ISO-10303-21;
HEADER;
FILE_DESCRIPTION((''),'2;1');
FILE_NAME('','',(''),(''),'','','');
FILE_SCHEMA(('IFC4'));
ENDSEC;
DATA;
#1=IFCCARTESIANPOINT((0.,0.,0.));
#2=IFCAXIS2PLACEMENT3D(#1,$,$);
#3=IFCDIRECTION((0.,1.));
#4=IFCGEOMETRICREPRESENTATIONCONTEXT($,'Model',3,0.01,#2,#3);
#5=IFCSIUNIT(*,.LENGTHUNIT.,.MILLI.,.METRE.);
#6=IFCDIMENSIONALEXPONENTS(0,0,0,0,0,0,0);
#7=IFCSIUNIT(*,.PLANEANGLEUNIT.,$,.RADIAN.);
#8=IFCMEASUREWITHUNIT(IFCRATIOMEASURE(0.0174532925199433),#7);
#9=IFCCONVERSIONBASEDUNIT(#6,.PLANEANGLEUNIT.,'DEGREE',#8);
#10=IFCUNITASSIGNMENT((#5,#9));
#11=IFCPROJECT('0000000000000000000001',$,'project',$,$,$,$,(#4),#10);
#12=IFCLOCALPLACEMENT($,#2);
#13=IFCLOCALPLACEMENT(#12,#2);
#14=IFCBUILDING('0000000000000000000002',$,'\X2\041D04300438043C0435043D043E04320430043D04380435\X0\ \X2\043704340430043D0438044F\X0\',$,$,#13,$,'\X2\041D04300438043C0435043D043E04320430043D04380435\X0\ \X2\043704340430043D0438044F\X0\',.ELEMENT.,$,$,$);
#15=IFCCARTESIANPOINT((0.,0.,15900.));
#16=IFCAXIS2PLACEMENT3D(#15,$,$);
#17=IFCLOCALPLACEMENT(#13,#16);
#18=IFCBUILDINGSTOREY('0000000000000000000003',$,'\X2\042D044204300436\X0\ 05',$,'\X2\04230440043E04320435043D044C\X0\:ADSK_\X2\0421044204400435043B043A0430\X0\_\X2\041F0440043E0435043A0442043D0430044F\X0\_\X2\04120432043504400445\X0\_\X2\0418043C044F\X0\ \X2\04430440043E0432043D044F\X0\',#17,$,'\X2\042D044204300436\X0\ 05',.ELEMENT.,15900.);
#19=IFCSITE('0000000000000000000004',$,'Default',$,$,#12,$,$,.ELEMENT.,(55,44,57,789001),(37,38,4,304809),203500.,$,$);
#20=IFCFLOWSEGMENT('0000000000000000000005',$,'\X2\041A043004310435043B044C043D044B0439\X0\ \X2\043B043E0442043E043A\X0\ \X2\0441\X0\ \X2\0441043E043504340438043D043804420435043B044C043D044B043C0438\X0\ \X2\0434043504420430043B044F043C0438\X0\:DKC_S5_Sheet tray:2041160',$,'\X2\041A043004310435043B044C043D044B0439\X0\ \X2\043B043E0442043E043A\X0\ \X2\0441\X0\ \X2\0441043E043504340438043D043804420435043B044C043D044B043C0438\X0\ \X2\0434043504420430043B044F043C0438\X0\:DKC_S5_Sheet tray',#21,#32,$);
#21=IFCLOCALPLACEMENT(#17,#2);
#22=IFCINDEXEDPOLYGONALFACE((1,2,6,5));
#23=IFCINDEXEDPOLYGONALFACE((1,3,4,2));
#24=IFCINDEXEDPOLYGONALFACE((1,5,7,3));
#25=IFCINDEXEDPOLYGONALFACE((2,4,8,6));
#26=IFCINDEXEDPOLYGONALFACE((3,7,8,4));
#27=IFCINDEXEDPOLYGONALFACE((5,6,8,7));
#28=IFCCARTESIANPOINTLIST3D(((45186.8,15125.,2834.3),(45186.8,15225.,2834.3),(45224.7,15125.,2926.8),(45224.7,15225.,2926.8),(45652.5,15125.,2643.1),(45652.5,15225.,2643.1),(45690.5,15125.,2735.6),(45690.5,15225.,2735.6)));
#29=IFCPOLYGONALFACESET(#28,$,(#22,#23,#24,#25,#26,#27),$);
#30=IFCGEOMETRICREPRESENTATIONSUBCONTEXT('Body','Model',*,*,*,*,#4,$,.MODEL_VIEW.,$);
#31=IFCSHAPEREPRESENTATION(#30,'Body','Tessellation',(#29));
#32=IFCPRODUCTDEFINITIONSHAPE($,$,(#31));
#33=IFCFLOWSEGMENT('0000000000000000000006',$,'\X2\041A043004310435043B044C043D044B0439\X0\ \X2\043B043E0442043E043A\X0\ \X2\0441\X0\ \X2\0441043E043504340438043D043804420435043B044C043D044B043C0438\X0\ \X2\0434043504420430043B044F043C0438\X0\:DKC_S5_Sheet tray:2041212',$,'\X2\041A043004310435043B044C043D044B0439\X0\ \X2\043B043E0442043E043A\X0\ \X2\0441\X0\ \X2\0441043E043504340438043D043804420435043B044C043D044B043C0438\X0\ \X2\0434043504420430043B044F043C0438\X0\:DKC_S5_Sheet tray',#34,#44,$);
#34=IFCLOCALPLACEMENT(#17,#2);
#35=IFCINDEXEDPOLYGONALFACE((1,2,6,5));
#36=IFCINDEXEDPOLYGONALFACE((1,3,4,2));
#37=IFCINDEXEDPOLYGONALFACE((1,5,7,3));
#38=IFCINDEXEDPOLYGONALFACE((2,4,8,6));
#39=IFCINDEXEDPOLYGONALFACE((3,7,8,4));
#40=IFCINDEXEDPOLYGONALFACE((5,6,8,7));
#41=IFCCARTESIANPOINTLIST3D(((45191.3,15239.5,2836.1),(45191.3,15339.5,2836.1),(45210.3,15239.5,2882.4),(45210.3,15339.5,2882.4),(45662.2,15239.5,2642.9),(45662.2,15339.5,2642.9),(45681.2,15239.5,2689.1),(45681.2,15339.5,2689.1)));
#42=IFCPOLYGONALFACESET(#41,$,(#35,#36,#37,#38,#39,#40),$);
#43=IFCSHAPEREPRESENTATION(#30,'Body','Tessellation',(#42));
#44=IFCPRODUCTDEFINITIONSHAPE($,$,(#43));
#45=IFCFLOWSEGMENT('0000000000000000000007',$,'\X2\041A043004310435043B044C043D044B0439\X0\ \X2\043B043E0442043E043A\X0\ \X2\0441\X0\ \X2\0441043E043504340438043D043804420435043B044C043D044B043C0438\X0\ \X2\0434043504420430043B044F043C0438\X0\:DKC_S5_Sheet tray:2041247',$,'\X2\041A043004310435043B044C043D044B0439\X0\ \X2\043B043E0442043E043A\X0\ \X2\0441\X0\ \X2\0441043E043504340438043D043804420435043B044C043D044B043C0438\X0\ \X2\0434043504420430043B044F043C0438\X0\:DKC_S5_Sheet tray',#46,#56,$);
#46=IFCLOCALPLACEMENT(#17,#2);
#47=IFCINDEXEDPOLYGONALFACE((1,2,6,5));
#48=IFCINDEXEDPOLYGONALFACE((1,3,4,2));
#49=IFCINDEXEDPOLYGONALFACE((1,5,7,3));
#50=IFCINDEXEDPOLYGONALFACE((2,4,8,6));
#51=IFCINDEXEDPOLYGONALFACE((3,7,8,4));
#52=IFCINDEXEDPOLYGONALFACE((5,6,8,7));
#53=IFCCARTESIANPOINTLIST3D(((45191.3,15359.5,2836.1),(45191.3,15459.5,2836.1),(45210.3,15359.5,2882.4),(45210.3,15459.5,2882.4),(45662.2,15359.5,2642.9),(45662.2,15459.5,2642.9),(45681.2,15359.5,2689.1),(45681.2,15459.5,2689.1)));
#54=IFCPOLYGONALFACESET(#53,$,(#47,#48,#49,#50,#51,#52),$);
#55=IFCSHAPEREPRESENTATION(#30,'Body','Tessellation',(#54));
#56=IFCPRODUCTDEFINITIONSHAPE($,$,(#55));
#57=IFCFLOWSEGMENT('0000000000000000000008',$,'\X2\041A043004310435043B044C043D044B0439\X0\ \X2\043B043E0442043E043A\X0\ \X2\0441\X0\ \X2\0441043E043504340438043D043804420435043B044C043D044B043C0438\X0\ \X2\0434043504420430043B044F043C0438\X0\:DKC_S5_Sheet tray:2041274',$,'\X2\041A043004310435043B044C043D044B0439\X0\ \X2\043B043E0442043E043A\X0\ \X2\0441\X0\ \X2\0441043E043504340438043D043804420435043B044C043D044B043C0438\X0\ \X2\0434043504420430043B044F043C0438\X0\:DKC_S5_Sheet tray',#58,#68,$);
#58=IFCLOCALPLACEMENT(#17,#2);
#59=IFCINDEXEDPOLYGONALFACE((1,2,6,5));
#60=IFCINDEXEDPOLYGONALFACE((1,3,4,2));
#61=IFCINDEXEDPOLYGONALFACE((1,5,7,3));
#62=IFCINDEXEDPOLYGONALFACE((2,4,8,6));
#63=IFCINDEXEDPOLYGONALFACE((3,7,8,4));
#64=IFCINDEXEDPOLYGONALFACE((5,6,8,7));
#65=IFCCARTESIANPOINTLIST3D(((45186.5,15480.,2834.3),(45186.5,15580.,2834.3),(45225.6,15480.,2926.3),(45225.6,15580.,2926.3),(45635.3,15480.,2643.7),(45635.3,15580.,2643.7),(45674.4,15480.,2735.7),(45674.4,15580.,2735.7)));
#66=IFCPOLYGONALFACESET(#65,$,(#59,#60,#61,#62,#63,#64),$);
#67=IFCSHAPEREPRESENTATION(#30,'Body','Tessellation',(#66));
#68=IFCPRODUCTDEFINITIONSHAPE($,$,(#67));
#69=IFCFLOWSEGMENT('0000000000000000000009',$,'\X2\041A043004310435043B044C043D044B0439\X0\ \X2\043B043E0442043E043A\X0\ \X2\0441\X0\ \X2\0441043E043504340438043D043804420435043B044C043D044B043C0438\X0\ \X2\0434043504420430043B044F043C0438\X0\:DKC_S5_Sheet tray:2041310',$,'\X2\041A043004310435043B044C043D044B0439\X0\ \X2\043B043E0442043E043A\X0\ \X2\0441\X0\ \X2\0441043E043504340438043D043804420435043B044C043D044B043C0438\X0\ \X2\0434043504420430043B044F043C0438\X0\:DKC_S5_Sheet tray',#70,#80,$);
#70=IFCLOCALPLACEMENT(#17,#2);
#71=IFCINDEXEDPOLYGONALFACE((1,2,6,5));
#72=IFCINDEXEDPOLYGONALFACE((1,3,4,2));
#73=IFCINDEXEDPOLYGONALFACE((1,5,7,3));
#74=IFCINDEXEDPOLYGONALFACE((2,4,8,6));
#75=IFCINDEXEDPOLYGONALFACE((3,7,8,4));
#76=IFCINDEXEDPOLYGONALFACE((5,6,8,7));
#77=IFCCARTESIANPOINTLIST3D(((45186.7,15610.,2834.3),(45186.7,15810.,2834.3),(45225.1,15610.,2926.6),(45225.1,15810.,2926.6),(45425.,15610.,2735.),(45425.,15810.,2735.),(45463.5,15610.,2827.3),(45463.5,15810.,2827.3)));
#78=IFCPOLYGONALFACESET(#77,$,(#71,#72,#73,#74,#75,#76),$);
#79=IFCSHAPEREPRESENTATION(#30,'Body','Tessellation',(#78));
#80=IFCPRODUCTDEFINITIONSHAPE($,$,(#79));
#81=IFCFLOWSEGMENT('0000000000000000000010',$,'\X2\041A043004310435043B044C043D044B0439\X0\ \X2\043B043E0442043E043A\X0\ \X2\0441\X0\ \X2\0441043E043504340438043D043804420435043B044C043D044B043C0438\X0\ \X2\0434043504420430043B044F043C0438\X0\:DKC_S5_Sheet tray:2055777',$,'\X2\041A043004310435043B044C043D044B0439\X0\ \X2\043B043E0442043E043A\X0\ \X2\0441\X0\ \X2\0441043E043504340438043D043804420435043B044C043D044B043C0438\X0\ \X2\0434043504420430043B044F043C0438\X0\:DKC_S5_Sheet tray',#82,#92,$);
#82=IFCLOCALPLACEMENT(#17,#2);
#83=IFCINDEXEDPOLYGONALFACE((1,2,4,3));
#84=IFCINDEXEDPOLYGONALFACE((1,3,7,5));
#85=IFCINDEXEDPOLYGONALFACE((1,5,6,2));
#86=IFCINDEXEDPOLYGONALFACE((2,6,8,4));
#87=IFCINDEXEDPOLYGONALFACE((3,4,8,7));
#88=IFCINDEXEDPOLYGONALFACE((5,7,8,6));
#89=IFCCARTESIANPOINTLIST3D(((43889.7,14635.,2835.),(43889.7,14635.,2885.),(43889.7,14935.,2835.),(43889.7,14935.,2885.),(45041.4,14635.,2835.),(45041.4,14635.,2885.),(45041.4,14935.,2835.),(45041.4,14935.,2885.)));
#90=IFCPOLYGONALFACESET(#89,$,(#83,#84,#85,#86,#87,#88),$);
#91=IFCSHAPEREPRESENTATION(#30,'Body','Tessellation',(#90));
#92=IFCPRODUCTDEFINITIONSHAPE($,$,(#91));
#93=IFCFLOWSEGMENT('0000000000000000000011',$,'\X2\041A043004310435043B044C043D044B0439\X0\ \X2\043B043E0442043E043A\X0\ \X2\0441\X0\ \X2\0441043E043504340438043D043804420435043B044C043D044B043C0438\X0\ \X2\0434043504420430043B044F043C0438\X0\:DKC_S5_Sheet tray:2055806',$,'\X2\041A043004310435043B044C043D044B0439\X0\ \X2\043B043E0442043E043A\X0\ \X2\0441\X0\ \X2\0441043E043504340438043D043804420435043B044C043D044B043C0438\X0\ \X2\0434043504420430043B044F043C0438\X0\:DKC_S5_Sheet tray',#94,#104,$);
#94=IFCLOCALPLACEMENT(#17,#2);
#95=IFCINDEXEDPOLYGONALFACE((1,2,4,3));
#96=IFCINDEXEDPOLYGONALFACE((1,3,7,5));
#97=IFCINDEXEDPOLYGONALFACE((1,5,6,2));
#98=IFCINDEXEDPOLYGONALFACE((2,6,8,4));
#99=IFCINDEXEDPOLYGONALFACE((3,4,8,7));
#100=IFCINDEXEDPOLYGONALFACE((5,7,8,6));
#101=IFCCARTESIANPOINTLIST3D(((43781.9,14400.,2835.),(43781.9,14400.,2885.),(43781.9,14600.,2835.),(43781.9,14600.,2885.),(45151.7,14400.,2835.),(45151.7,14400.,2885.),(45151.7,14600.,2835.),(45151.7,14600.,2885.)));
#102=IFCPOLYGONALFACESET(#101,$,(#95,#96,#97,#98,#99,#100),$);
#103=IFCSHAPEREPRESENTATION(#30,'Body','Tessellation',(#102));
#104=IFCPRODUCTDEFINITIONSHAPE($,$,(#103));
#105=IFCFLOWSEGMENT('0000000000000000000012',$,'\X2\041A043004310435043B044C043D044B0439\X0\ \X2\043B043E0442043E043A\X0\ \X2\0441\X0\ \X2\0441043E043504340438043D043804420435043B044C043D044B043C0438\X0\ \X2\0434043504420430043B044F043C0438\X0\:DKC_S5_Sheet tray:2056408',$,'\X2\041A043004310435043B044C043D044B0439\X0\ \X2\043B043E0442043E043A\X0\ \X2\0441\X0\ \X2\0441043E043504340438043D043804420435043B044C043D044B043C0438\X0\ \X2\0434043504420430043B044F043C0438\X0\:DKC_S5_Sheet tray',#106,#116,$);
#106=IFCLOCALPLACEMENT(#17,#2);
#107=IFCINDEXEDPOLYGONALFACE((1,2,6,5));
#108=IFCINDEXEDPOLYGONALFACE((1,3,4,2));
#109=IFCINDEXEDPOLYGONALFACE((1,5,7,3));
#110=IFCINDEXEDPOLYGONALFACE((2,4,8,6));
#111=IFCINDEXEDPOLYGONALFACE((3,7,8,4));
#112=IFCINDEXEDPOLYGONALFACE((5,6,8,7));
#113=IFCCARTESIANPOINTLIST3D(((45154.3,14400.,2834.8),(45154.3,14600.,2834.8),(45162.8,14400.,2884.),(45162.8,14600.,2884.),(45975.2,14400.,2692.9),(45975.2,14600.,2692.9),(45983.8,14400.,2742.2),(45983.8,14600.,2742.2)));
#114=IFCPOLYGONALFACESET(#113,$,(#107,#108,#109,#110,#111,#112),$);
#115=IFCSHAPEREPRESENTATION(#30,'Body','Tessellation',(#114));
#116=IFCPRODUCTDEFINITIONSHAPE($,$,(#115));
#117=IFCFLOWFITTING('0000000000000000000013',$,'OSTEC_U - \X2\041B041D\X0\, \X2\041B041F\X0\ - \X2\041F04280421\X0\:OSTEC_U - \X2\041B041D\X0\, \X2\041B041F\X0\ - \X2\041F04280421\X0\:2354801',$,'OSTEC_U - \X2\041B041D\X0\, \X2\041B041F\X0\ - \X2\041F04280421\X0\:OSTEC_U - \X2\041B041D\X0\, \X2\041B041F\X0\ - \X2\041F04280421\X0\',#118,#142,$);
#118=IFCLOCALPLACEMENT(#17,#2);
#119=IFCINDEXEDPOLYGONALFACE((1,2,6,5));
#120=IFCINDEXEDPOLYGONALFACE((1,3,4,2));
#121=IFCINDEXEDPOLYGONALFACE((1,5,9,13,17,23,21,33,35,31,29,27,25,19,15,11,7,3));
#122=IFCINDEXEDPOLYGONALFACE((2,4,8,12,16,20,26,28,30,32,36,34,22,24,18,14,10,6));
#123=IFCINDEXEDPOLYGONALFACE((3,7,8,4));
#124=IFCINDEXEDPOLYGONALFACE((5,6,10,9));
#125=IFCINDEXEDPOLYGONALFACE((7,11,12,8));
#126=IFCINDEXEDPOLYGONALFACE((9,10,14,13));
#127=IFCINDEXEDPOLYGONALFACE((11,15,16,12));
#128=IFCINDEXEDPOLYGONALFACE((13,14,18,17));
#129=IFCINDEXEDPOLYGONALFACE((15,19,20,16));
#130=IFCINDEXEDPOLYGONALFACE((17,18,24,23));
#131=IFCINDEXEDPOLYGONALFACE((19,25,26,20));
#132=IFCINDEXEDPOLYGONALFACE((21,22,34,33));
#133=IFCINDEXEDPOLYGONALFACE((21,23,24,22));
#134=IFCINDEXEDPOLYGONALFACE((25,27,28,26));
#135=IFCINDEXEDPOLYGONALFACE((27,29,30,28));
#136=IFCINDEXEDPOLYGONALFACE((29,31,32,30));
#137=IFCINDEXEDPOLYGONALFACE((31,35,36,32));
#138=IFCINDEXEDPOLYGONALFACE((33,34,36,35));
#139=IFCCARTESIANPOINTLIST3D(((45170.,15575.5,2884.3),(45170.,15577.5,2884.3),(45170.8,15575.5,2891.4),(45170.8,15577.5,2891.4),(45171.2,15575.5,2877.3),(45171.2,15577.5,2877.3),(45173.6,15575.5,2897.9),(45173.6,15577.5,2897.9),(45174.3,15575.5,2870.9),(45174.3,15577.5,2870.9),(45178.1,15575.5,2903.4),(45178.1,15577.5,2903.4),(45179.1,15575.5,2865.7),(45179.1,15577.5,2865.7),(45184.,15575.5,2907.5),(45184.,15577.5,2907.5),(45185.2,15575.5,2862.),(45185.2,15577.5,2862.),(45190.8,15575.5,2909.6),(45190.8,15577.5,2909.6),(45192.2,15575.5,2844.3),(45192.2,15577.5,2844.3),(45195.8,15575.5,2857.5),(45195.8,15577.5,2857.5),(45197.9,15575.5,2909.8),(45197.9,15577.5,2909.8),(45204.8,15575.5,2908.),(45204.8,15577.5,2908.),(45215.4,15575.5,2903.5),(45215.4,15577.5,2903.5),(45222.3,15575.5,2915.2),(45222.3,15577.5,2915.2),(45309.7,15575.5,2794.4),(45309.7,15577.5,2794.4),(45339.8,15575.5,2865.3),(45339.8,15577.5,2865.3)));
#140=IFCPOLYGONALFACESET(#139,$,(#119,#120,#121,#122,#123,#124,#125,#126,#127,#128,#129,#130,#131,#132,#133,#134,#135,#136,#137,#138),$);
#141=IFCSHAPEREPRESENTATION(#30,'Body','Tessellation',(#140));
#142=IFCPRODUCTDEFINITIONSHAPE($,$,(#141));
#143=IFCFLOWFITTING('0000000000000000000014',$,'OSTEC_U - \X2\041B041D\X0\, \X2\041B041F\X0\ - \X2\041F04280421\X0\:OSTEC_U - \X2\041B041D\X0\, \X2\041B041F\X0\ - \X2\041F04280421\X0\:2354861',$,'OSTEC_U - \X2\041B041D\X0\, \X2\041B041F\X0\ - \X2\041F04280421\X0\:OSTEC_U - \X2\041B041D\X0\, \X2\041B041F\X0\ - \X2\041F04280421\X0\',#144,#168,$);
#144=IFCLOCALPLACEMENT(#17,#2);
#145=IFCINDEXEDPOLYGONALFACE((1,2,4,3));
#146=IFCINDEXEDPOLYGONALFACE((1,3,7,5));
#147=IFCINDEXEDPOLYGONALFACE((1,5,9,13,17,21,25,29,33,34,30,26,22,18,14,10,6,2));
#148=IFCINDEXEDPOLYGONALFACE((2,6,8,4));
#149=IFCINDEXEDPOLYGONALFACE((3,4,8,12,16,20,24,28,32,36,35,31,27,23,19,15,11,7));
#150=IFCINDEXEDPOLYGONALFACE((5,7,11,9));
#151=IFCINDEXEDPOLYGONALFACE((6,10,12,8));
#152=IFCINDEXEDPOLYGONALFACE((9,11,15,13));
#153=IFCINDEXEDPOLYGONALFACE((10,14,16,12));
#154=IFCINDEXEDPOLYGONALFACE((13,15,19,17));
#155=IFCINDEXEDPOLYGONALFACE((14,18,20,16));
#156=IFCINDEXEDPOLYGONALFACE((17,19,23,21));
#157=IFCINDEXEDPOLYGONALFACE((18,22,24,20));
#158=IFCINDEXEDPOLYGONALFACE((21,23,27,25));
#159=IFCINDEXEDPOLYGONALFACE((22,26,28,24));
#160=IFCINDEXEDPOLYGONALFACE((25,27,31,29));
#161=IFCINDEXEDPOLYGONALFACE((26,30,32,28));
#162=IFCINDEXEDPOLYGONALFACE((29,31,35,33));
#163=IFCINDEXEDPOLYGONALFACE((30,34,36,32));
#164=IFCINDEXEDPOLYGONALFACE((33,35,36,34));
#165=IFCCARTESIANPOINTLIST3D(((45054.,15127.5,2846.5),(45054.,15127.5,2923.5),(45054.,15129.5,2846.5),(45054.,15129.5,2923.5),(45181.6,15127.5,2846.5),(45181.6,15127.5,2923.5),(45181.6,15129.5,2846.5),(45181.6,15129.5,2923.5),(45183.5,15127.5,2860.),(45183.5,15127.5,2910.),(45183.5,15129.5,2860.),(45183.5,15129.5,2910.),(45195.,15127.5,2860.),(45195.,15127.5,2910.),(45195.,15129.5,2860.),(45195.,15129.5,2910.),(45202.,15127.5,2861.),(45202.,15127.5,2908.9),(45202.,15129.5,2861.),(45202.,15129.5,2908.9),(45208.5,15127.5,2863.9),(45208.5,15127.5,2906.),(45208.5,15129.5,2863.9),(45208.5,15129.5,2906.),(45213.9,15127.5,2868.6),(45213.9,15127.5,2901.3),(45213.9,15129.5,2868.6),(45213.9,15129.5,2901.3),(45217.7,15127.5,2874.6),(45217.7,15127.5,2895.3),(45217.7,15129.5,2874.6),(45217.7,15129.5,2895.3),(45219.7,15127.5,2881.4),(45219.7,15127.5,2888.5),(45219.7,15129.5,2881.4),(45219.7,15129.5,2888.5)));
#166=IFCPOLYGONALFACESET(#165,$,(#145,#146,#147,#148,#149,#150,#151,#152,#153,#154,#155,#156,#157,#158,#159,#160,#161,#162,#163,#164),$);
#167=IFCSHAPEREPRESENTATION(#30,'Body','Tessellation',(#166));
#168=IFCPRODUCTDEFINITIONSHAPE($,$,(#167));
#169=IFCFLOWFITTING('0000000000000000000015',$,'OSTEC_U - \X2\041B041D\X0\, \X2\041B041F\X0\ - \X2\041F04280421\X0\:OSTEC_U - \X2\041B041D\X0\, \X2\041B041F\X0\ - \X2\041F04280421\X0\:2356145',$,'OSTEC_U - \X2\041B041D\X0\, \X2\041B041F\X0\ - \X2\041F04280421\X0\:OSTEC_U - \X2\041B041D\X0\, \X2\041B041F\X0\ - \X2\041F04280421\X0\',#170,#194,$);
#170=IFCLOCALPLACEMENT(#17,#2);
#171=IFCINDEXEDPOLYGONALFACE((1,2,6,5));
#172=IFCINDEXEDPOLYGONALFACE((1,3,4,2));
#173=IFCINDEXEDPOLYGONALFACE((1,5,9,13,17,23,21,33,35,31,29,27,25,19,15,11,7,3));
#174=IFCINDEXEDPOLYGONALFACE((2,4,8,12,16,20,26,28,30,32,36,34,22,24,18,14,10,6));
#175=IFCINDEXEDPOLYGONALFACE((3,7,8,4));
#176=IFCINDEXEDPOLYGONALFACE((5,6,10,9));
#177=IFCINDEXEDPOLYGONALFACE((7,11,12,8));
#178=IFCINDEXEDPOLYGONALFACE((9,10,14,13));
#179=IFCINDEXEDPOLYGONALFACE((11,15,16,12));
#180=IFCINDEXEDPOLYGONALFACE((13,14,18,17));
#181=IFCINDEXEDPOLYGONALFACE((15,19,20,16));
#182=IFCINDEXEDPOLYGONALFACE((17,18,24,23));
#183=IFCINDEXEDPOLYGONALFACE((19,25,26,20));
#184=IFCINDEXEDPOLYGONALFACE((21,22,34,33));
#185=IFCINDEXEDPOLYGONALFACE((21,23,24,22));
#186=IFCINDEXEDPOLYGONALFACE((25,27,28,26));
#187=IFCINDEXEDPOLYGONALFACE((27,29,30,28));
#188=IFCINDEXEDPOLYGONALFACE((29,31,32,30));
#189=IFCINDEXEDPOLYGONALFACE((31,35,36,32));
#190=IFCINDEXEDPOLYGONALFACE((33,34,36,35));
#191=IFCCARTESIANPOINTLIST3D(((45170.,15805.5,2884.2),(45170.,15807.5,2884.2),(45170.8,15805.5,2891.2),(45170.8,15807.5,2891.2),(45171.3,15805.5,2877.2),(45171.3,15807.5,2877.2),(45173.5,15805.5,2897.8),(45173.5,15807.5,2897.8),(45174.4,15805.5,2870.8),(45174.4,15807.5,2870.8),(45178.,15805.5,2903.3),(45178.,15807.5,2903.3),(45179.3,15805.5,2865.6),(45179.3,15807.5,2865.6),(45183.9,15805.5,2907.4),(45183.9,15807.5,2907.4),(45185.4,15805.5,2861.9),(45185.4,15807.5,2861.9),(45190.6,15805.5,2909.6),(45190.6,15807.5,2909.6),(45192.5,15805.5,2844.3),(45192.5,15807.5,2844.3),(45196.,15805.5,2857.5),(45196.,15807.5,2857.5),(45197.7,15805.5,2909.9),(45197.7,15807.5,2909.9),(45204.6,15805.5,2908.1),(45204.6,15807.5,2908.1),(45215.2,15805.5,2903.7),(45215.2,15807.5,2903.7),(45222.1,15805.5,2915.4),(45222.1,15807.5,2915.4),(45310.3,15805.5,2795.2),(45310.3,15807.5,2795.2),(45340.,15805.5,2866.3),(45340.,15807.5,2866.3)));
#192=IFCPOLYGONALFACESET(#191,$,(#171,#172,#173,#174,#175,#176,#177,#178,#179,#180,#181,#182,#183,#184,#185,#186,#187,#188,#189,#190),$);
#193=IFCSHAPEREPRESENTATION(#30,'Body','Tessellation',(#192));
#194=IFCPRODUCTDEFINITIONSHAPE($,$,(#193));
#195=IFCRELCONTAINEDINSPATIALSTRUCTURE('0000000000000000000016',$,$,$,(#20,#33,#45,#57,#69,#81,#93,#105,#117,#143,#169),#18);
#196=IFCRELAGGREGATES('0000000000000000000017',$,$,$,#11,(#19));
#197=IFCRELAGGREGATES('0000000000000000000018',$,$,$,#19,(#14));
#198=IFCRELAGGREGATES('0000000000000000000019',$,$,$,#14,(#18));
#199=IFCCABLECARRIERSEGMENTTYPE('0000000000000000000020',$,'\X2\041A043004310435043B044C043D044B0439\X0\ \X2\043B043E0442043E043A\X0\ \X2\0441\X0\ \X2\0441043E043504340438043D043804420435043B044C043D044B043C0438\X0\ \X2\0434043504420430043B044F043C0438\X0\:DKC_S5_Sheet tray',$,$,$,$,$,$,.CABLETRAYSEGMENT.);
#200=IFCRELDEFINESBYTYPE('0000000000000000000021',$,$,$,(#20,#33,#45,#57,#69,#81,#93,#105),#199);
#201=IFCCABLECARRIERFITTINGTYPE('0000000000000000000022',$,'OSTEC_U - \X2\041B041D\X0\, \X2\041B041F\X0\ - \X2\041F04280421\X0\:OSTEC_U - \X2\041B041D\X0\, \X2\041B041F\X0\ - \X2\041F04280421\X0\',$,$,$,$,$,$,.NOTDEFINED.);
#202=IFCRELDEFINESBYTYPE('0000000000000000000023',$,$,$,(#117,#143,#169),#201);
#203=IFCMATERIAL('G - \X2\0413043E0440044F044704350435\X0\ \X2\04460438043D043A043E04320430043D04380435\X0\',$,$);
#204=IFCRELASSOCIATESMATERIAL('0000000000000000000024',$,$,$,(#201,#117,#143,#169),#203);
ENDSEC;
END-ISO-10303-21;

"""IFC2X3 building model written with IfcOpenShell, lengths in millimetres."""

from ifc_helpers import new_model, entity, si_unit, converted_unit, direction, frame, frame_2d, origin, origin_2d_with_axis, place, context, subcontext, project, spatial, polyline, circle_curve, parameter, trimmed, segment, composite_curve, rectangle, outline, extrude, source, transform, mapped, material, type_object, type_shapes, element, save


model = new_model("IFC2X3")

# Units and contexts
model_context = context("Model", 3, precision=0.01, world=origin(), true_north=direction((0.0, 1.0)))
body_context = subcontext(model_context, "Body", "Model", "MODEL_VIEW")
ifc_project = project(units=[si_unit("LENGTHUNIT", "METRE", prefix="MILLI"), converted_unit("PLANEANGLEUNIT", "DEGREE", entity("IfcRatioMeasure", 0.0174532925199433), si_unit("PLANEANGLEUNIT", "RADIAN"), dimensions=[0, 0, 0, 0, 0, 0, 0])], contexts=[model_context])

# Site, building, storey
site_placement = place(None, frame((0.0, 0.0, 0.0)))
site = spatial("IfcSite", under=ifc_project, at=site_placement, Name="Default", CompositionType="ELEMENT", RefLatitude=(55, 44, 57, 789001), RefLongitude=(37, 38, 4, 304809), RefElevation=203500.0)
building_placement = place(site_placement, origin())
building = spatial("IfcBuilding", under=site, at=building_placement, Name="Наименование здания", LongName="Наименование здания", CompositionType="ELEMENT")
storey_placement = place(building_placement, frame((0.0, 0.0, 15900.0)))
storey = spatial("IfcBuildingStorey", under=building, at=storey_placement, Name="Этаж 05", ObjectType="Уровень:ADSK_Стрелка_Проектная_Вверх_Имя уровня", LongName="Этаж 05", CompositionType="ELEMENT", Elevation=15900.0)

# Flow segments
cable_carrier_segment_type = type_object("IfcCableCarrierSegmentType", Name="Кабельный лоток с соединительными деталями:DKC_S5_Sheet tray", PredefinedType="CABLETRAYSEGMENT")
flow_segment_1_placement = place(storey_placement, frame((45186.8, 15125.0, 2643.1)))
element("IfcFlowSegment", 1, at=flow_segment_1_placement, inside=storey, type_object=cable_carrier_segment_type, Name="Кабельный лоток с соединительными деталями:DKC_S5_Sheet tray:2041160", ObjectType="Кабельный лоток с соединительными деталями:DKC_S5_Sheet tray", context=body_context, shape_type="SweptSolid", body=[
    extrude(rectangle(XDim=100.0, YDim=100.0, at=frame_2d((0.0, 0.0), x_axis=(1.0, 0.0))), frame((19.0, 50.0, 237.4), z_axis=(0.925113, 0.0, -0.379692), x_axis=(0.379692, 0.0, 0.925113)), (0.0, 0.0, 1.0), 503.5),
])
flow_segment_2_placement = place(storey_placement, frame((45191.3, 15239.5, 2642.9)))
element("IfcFlowSegment", 2, at=flow_segment_2_placement, inside=storey, type_object=cable_carrier_segment_type, Name="Кабельный лоток с соединительными деталями:DKC_S5_Sheet tray:2041212", ObjectType="Кабельный лоток с соединительными деталями:DKC_S5_Sheet tray", context=body_context, shape_type="SweptSolid", body=[
    extrude(rectangle(XDim=50.0, YDim=100.0, at=frame_2d((0.0, 0.0), x_axis=(1.0, 0.0))), frame((9.5, 50.0, 216.4), z_axis=(0.925113, 0.0, -0.379692), x_axis=(0.379692, 0.0, 0.925113)), (0.0, 0.0, 1.0), 509.0),
])
flow_segment_3_placement = place(storey_placement, frame((45191.3, 15359.5, 2642.9)))
element("IfcFlowSegment", 3, at=flow_segment_3_placement, inside=storey, type_object=cable_carrier_segment_type, Name="Кабельный лоток с соединительными деталями:DKC_S5_Sheet tray:2041247", ObjectType="Кабельный лоток с соединительными деталями:DKC_S5_Sheet tray", context=body_context, shape_type="SweptSolid", body=[
    extrude(rectangle(XDim=50.0, YDim=100.0, at=origin_2d_with_axis()), frame((9.5, 50.0, 216.4), z_axis=(0.925113, 0.0, -0.379692), x_axis=(0.379692, 0.0, 0.925113)), (0.0, 0.0, 1.0), 509.0),
])
flow_segment_4_placement = place(storey_placement, frame((45186.5, 15480.0, 2643.7)))
element("IfcFlowSegment", 4, at=flow_segment_4_placement, inside=storey, type_object=cable_carrier_segment_type, Name="Кабельный лоток с соединительными деталями:DKC_S5_Sheet tray:2041274", ObjectType="Кабельный лоток с соединительными деталями:DKC_S5_Sheet tray", context=body_context, shape_type="SweptSolid", body=[
    extrude(rectangle(XDim=100.0, YDim=100.0, at=frame_2d((0.0, 0.0), x_axis=(1.0, 0.0))), frame((19.5, 50.0, 236.6), z_axis=(0.920411, 0.0, -0.390951), x_axis=(0.390951, 0.0, 0.920411)), (0.0, 0.0, 1.0), 487.6),
])
flow_segment_5_placement = place(storey_placement, frame((45186.7, 15610.0, 2735.0)))
element("IfcFlowSegment", 5, at=flow_segment_5_placement, inside=storey, type_object=cable_carrier_segment_type, Name="Кабельный лоток с соединительными деталями:DKC_S5_Sheet tray:2041310", ObjectType="Кабельный лоток с соединительными деталями:DKC_S5_Sheet tray", context=body_context, shape_type="SweptSolid", body=[
    extrude(rectangle(XDim=100.0, YDim=200.0, at=frame_2d((0.0, 0.0), x_axis=(1.0, 0.0))), frame((19.2, 100.0, 145.5), z_axis=(0.923077, 0.0, -0.384615), x_axis=(0.384615, 0.0, 0.923077)), (0.0, 0.0, 1.0), 258.2),
])
flow_segment_6_placement = place(storey_placement, frame((43889.7, 14635.0, 2835.0)))
element("IfcFlowSegment", 6, at=flow_segment_6_placement, inside=storey, type_object=cable_carrier_segment_type, Name="Кабельный лоток с соединительными деталями:DKC_S5_Sheet tray:2055777", ObjectType="Кабельный лоток с соединительными деталями:DKC_S5_Sheet tray", context=body_context, shape_type="SweptSolid", body=[
    extrude(rectangle(XDim=1151.7, YDim=300.0, at=frame_2d((0.0, 0.0), x_axis=(1.0, 0.0))), frame((575.9, 150.0, 0.0)), (0.0, 0.0, 1.0), 50.0),
])
flow_segment_7_placement = place(storey_placement, frame((43781.9, 14400.0, 2835.0)))
element("IfcFlowSegment", 7, at=flow_segment_7_placement, inside=storey, type_object=cable_carrier_segment_type, Name="Кабельный лоток с соединительными деталями:DKC_S5_Sheet tray:2055806", ObjectType="Кабельный лоток с соединительными деталями:DKC_S5_Sheet tray", context=body_context, shape_type="SweptSolid", body=[
    extrude(rectangle(XDim=1369.7, YDim=200.0, at=frame_2d((0.0, 0.0), x_axis=(1.0, 0.0))), frame((684.9, 100.0, 0.0)), (0.0, 0.0, 1.0), 50.0),
])
flow_segment_8_placement = place(storey_placement, frame((45154.3, 14400.0, 2692.9)))
element("IfcFlowSegment", 8, at=flow_segment_8_placement, inside=storey, type_object=cable_carrier_segment_type, Name="Кабельный лоток с соединительными деталями:DKC_S5_Sheet tray:2056408", ObjectType="Кабельный лоток с соединительными деталями:DKC_S5_Sheet tray", context=body_context, shape_type="SweptSolid", body=[
    extrude(rectangle(XDim=50.0, YDim=200.0, at=origin_2d_with_axis()), frame((4.3, 100.0, 166.5), z_axis=(0.985391, 0.0, -0.170307), x_axis=(0.170307, 0.0, 0.985391)), (0.0, 0.0, 1.0), 833.1),
])

# Flow fittings
ifc_material_1 = material(Name="G - Горячее цинкование")
cable_carrier_fitting_type_1 = type_object("IfcCableCarrierFittingType", Name="OSTEC_U - ЛН, ЛП - ПШС:OSTEC_U - ЛН, ЛП - ПШС", PredefinedType="NOTDEFINED", material=ifc_material_1)
shared_shape_1 = source(origin(), body_context, "Body", "SweptSolid", [
    extrude(outline(composite_curve([segment(trimmed(circle_curve(frame_2d((-41.5, 0.0), x_axis=(1.0, 0.0)), 25.0), [parameter(90.0)], [parameter(270.0)], True, "PARAMETER"), True, "CONTINUOUS"), segment(polyline([(-41.5, -25.0), (-30.0, -25.0)]), True, "CONTINUOUS"), segment(polyline([(-30.0, -25.0), (-28.1, -38.5)]), True, "CONTINUOUS"), segment(polyline([(-28.1, -38.5), (99.5, -38.5)]), True, "CONTINUOUS"), segment(polyline([(99.5, -38.5), (99.5, 38.5)]), True, "CONTINUOUS"), segment(polyline([(99.5, 38.5), (-28.1, 38.5)]), True, "CONTINUOUS"), segment(polyline([(-28.1, 38.5), (-30.0, 25.0)]), True, "CONTINUOUS"), segment(polyline([(-30.0, 25.0), (-41.5, 25.0)]), True, "CONTINUOUS")], self_intersect=False)), frame((41.5, 0.0, 0.0), z_axis=(0.0, 0.0, -1.0), x_axis=(1.0, 0.0, 0.0)), (0.0, 0.0, -1.0), 2.0),
])
type_shapes(cable_carrier_fitting_type_1, [shared_shape_1])
for number, where, z_axis, x_axis, name in (
    (9, (45195.0, 15575.5, 2885.0), (0.0, 1.0, 0.0), (0.920411, 0.0, -0.390951), "OSTEC_U - ЛН, ЛП - ПШС:OSTEC_U - ЛН, ЛП - ПШС:2354801"),
    (10, (45195.0, 15129.5, 2885.0), (0.0, -1.0, 0.0), (-1.0, 0.0, 0.0), "OSTEC_U - ЛН, ЛП - ПШС:OSTEC_U - ЛН, ЛП - ПШС:2354861"),
    (11, (45195.0, 15805.5, 2885.0), (0.0, 1.0, 0.0), (0.923077, 0.0, -0.384615), "OSTEC_U - ЛН, ЛП - ПШС:OSTEC_U - ЛН, ЛП - ПШС:2356145"),
):
    element("IfcFlowFitting", number, at=place(storey_placement, frame(where, z_axis=z_axis, x_axis=x_axis)), inside=storey, type_object=cable_carrier_fitting_type_1, material=ifc_material_1, Name=name, ObjectType="OSTEC_U - ЛН, ЛП - ПШС:OSTEC_U - ЛН, ЛП - ПШС", context=body_context, shape_type="MappedRepresentation", body=[
        mapped(shared_shape_1, transform((0.0, 0.0, 0.0), scale=1.0)),
    ])

save(model, "model.ifc")
